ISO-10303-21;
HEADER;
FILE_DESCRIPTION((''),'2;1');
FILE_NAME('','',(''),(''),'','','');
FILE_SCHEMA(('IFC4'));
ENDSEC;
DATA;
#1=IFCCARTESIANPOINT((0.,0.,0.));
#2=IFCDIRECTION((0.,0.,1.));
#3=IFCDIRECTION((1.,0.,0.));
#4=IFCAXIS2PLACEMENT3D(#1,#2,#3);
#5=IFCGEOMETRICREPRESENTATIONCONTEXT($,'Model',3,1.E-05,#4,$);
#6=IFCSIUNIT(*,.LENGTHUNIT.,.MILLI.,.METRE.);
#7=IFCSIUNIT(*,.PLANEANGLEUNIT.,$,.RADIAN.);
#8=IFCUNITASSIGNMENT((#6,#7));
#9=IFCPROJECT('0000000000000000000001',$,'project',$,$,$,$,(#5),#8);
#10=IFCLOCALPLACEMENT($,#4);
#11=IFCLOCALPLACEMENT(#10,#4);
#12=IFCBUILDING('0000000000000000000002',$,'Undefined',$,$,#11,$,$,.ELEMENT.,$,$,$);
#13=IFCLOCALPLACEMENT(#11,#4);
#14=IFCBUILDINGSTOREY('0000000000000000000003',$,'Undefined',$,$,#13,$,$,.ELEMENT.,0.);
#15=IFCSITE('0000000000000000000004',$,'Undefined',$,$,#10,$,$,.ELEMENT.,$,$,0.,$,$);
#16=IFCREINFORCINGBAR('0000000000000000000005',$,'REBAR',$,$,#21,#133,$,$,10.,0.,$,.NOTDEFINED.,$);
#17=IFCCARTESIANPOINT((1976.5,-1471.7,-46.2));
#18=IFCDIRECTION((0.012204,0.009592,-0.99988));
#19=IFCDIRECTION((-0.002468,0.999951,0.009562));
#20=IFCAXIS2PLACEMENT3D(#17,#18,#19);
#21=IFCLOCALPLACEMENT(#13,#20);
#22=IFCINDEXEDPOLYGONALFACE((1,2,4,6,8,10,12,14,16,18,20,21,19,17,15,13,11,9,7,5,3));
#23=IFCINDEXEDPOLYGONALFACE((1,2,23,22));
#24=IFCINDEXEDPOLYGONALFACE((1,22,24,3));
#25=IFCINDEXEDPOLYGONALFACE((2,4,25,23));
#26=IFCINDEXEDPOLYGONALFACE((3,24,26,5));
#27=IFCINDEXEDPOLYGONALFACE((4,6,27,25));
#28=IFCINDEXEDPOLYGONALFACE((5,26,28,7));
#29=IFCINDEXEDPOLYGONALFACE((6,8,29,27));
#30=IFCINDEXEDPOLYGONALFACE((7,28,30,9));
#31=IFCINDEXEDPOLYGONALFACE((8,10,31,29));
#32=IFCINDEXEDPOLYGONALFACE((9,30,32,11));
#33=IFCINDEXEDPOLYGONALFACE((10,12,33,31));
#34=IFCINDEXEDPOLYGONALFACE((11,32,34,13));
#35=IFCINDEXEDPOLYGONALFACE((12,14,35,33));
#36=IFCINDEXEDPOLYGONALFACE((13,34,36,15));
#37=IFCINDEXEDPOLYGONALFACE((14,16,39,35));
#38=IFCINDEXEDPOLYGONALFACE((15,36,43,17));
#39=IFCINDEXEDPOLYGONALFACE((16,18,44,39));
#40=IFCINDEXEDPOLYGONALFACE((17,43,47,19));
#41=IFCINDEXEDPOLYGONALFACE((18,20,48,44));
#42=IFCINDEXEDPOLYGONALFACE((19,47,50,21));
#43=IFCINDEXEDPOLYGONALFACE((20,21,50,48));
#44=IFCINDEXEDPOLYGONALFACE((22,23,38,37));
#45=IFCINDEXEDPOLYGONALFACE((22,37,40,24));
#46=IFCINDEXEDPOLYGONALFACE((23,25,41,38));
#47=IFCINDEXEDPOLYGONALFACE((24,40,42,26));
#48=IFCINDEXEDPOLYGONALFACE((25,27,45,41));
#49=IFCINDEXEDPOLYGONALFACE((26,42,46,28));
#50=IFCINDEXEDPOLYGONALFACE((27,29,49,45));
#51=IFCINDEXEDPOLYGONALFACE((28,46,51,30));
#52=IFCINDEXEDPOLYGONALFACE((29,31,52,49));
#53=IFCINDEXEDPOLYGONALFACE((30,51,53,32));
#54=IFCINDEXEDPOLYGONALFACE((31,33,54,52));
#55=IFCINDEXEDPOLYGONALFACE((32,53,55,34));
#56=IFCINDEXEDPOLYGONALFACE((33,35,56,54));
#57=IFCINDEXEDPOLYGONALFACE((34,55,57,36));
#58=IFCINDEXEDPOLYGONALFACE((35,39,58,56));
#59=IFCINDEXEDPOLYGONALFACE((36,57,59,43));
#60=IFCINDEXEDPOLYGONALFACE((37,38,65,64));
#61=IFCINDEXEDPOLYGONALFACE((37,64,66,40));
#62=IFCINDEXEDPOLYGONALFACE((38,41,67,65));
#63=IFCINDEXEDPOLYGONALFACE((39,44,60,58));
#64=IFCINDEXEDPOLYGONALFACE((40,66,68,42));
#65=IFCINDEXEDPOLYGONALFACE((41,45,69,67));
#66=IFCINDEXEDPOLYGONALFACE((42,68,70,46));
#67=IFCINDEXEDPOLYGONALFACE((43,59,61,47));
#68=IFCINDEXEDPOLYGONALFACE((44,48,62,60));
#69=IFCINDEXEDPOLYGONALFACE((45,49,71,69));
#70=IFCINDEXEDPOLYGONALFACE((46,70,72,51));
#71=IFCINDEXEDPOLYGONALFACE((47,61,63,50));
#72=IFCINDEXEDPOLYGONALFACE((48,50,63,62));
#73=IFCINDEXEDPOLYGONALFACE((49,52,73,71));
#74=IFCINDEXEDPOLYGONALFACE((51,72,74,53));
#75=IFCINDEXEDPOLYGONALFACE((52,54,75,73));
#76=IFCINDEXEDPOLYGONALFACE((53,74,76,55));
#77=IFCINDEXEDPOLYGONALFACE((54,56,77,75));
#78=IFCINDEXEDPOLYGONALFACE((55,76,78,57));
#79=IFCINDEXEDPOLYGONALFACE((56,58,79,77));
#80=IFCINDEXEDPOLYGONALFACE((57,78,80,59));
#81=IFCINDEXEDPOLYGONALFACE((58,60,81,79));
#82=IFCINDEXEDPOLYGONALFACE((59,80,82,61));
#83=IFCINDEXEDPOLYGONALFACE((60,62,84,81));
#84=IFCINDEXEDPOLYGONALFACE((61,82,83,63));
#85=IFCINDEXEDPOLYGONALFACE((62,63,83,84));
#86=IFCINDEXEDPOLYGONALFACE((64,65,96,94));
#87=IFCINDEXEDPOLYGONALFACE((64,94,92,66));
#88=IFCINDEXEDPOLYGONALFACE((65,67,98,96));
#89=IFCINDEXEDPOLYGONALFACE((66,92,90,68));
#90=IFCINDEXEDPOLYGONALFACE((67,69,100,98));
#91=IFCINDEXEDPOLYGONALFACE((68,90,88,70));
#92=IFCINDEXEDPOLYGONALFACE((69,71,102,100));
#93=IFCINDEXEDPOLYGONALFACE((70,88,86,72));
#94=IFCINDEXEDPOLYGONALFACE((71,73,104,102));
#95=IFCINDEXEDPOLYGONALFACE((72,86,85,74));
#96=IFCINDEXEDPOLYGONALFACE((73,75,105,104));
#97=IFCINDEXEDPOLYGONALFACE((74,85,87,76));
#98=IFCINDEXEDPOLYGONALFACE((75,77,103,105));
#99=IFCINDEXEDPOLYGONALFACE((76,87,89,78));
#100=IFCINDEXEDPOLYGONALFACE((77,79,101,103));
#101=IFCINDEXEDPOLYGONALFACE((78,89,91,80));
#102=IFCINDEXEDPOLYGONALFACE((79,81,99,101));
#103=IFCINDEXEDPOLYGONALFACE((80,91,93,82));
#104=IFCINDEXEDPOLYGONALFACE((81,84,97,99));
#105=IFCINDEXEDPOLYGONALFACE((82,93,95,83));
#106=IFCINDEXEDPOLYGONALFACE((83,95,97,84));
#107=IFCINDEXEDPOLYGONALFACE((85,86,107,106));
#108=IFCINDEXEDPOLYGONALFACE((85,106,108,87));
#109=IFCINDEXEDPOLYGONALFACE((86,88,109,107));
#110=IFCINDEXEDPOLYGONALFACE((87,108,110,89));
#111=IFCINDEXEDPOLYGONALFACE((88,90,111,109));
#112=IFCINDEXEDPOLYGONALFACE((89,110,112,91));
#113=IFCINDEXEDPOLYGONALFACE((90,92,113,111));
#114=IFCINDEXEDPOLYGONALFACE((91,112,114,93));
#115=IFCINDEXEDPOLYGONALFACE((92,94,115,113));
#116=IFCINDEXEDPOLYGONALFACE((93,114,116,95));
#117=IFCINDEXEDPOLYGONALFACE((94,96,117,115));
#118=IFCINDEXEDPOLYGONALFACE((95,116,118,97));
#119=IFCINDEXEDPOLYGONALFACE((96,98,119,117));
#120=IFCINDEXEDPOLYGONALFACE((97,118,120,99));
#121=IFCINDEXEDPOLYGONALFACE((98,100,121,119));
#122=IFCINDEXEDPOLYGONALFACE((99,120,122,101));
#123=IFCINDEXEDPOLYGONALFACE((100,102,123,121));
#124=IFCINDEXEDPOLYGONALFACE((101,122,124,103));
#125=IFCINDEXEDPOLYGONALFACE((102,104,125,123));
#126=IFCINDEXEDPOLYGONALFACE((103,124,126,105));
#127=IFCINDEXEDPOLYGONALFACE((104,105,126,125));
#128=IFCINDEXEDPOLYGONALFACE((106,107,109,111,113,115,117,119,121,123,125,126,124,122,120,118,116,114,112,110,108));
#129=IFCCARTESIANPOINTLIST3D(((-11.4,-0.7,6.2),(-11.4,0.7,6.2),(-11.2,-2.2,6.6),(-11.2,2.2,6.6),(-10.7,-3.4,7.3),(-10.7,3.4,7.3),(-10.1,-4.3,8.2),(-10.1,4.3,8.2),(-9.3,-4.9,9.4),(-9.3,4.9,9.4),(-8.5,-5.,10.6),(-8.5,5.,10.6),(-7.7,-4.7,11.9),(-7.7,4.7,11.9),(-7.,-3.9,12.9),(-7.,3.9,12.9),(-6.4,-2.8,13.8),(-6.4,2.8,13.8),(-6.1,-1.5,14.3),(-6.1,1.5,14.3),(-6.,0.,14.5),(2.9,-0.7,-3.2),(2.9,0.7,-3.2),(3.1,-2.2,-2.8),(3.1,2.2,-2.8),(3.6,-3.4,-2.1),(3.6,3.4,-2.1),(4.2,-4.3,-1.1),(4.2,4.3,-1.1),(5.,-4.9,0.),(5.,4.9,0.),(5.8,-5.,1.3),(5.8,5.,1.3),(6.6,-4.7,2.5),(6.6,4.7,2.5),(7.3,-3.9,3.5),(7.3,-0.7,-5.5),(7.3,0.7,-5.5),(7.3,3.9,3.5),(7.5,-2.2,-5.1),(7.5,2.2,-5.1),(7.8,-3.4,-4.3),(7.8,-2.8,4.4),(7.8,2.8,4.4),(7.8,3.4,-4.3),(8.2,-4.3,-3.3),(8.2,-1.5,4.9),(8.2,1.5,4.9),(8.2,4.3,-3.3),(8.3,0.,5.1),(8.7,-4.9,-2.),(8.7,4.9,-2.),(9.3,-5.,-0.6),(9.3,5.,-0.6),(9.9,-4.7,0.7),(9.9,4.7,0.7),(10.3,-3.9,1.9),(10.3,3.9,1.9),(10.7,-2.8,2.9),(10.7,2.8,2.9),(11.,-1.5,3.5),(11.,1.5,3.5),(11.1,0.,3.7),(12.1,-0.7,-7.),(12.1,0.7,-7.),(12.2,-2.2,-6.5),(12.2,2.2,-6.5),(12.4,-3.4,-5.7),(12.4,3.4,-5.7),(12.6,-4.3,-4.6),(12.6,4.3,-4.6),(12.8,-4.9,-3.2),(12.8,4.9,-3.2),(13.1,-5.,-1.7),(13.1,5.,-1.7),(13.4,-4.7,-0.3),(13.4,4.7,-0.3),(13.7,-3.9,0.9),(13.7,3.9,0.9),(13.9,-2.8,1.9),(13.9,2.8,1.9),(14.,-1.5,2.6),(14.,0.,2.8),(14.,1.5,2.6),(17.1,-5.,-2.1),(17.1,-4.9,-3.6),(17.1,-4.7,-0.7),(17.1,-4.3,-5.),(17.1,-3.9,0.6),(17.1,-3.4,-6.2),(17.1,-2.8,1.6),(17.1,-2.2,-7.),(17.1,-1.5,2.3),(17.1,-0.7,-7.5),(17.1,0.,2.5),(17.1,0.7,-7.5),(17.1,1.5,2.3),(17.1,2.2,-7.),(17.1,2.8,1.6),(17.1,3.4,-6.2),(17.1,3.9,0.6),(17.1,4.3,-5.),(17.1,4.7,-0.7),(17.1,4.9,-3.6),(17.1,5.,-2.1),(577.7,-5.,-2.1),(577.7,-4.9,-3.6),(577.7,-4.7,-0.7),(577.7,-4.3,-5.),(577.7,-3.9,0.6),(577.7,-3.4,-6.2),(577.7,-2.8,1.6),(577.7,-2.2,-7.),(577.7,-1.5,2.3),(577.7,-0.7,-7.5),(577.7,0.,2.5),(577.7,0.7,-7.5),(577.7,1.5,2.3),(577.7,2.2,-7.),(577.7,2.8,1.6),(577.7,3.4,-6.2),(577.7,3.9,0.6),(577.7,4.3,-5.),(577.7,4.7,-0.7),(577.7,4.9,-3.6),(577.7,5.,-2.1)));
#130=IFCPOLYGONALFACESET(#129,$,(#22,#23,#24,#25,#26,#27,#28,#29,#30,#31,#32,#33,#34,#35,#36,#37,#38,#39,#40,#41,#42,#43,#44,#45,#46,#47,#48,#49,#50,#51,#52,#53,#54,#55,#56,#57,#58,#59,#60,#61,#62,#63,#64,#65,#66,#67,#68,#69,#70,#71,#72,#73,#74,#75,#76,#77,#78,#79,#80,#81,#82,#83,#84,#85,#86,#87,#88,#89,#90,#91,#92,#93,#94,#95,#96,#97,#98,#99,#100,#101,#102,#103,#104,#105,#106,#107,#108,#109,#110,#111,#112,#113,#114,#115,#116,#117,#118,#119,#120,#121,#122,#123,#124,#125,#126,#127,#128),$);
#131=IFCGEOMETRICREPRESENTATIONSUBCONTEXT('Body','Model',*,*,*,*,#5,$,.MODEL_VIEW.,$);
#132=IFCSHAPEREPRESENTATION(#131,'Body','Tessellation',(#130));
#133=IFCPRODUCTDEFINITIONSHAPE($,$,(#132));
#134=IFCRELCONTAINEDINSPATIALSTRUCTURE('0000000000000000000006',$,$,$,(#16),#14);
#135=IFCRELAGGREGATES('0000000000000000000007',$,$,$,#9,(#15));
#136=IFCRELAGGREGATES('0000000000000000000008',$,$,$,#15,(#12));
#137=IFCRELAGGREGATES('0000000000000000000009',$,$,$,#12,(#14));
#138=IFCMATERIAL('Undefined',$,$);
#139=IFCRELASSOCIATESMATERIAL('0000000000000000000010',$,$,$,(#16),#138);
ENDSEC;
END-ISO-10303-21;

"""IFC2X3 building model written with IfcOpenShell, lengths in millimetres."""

from ifc_helpers import new_model, entity, si_unit, frame, origin_with_axes, place, context, subcontext, project, spatial, source, transform, mapped, material, element, save


model = new_model("IFC2X3")

# Units and contexts
model_context = context("Model", 3, precision=1e-05, world=origin_with_axes())
body_context = subcontext(model_context, "Body", "Model", "MODEL_VIEW")
ifc_project = project(units=[si_unit("LENGTHUNIT", "METRE", prefix="MILLI"), si_unit("PLANEANGLEUNIT", "RADIAN")], contexts=[model_context])

# Site, building, storey
site_placement = place(None, origin_with_axes())
site = spatial("IfcSite", under=ifc_project, at=site_placement, Name="Undefined", CompositionType="ELEMENT", RefElevation=0.0)
building_placement = place(site_placement, origin_with_axes())
building = spatial("IfcBuilding", under=site, at=building_placement, Name="Undefined", CompositionType="ELEMENT")
storey_placement = place(building_placement, origin_with_axes())
storey = spatial("IfcBuildingStorey", under=building, at=storey_placement, Name="Undefined", CompositionType="ELEMENT", Elevation=0.0)

# Reinforcing bar
ifc_material_1 = material(Name="Undefined")
shared_shape_1 = source(origin_with_axes(), body_context, "Body", "AdvancedSweptSolid", [
    entity("IfcSweptDiskSolid", entity("IfcCompositeCurve", [entity("IfcCompositeCurveSegment", "CONTINUOUS", True, entity("IfcTrimmedCurve", entity("IfcLine", entity("IfcCartesianPoint", [0.0, 0.0, 0.0]), entity("IfcVector", entity("IfcDirection", [0.835483, 0.0, -0.549516]), 1.0)), [entity("IfcParameterValue", 0.0)], [entity("IfcParameterValue", 17.082101)], True, "PARAMETER")), entity("IfcCompositeCurveSegment", "CONTINUOUS", True, entity("IfcTrimmedCurve", entity("IfcCircle", entity("IfcAxis2Placement3D", entity("IfcCartesianPoint", [25.8, 0.0, 8.2]), entity("IfcDirection", [0.0, -1.0, 0.0]), entity("IfcDirection", [-0.549516, 0.0, -0.835483])), 21.0), [entity("IfcParameterValue", 0.0)], [entity("IfcParameterValue", 0.581785)], True, "PARAMETER")), entity("IfcCompositeCurveSegment", "DISCONTINUOUS", True, entity("IfcTrimmedCurve", entity("IfcLine", entity("IfcCartesianPoint", [25.8, 0.0, -12.8]), entity("IfcVector", entity("IfcDirection", [1.0, 0.0, 0.0]), 1.0)), [entity("IfcParameterValue", 0.0)], [entity("IfcParameterValue", 560.593055)], True, "PARAMETER"))], False), 5.0, None, 0.0, 578.3),
])
reinforcing_bar_1_placement = place(storey_placement, frame((1976.5, -1471.7, -46.2), z_axis=(0.012204, 0.009592, -0.99988), x_axis=(-0.002468, 0.999951, 0.009562)))
element("IfcReinforcingBar", 1, at=reinforcing_bar_1_placement, inside=storey, material=ifc_material_1, Name="REBAR", BarRole="NOTDEFINED", CrossSectionArea=0.0, NominalDiameter=10.0, context=body_context, shape_type="MappedRepresentation", body=[
    mapped(shared_shape_1, transform((-8.7, 0.0, 10.3))),
])

save(model, "model.ifc")
